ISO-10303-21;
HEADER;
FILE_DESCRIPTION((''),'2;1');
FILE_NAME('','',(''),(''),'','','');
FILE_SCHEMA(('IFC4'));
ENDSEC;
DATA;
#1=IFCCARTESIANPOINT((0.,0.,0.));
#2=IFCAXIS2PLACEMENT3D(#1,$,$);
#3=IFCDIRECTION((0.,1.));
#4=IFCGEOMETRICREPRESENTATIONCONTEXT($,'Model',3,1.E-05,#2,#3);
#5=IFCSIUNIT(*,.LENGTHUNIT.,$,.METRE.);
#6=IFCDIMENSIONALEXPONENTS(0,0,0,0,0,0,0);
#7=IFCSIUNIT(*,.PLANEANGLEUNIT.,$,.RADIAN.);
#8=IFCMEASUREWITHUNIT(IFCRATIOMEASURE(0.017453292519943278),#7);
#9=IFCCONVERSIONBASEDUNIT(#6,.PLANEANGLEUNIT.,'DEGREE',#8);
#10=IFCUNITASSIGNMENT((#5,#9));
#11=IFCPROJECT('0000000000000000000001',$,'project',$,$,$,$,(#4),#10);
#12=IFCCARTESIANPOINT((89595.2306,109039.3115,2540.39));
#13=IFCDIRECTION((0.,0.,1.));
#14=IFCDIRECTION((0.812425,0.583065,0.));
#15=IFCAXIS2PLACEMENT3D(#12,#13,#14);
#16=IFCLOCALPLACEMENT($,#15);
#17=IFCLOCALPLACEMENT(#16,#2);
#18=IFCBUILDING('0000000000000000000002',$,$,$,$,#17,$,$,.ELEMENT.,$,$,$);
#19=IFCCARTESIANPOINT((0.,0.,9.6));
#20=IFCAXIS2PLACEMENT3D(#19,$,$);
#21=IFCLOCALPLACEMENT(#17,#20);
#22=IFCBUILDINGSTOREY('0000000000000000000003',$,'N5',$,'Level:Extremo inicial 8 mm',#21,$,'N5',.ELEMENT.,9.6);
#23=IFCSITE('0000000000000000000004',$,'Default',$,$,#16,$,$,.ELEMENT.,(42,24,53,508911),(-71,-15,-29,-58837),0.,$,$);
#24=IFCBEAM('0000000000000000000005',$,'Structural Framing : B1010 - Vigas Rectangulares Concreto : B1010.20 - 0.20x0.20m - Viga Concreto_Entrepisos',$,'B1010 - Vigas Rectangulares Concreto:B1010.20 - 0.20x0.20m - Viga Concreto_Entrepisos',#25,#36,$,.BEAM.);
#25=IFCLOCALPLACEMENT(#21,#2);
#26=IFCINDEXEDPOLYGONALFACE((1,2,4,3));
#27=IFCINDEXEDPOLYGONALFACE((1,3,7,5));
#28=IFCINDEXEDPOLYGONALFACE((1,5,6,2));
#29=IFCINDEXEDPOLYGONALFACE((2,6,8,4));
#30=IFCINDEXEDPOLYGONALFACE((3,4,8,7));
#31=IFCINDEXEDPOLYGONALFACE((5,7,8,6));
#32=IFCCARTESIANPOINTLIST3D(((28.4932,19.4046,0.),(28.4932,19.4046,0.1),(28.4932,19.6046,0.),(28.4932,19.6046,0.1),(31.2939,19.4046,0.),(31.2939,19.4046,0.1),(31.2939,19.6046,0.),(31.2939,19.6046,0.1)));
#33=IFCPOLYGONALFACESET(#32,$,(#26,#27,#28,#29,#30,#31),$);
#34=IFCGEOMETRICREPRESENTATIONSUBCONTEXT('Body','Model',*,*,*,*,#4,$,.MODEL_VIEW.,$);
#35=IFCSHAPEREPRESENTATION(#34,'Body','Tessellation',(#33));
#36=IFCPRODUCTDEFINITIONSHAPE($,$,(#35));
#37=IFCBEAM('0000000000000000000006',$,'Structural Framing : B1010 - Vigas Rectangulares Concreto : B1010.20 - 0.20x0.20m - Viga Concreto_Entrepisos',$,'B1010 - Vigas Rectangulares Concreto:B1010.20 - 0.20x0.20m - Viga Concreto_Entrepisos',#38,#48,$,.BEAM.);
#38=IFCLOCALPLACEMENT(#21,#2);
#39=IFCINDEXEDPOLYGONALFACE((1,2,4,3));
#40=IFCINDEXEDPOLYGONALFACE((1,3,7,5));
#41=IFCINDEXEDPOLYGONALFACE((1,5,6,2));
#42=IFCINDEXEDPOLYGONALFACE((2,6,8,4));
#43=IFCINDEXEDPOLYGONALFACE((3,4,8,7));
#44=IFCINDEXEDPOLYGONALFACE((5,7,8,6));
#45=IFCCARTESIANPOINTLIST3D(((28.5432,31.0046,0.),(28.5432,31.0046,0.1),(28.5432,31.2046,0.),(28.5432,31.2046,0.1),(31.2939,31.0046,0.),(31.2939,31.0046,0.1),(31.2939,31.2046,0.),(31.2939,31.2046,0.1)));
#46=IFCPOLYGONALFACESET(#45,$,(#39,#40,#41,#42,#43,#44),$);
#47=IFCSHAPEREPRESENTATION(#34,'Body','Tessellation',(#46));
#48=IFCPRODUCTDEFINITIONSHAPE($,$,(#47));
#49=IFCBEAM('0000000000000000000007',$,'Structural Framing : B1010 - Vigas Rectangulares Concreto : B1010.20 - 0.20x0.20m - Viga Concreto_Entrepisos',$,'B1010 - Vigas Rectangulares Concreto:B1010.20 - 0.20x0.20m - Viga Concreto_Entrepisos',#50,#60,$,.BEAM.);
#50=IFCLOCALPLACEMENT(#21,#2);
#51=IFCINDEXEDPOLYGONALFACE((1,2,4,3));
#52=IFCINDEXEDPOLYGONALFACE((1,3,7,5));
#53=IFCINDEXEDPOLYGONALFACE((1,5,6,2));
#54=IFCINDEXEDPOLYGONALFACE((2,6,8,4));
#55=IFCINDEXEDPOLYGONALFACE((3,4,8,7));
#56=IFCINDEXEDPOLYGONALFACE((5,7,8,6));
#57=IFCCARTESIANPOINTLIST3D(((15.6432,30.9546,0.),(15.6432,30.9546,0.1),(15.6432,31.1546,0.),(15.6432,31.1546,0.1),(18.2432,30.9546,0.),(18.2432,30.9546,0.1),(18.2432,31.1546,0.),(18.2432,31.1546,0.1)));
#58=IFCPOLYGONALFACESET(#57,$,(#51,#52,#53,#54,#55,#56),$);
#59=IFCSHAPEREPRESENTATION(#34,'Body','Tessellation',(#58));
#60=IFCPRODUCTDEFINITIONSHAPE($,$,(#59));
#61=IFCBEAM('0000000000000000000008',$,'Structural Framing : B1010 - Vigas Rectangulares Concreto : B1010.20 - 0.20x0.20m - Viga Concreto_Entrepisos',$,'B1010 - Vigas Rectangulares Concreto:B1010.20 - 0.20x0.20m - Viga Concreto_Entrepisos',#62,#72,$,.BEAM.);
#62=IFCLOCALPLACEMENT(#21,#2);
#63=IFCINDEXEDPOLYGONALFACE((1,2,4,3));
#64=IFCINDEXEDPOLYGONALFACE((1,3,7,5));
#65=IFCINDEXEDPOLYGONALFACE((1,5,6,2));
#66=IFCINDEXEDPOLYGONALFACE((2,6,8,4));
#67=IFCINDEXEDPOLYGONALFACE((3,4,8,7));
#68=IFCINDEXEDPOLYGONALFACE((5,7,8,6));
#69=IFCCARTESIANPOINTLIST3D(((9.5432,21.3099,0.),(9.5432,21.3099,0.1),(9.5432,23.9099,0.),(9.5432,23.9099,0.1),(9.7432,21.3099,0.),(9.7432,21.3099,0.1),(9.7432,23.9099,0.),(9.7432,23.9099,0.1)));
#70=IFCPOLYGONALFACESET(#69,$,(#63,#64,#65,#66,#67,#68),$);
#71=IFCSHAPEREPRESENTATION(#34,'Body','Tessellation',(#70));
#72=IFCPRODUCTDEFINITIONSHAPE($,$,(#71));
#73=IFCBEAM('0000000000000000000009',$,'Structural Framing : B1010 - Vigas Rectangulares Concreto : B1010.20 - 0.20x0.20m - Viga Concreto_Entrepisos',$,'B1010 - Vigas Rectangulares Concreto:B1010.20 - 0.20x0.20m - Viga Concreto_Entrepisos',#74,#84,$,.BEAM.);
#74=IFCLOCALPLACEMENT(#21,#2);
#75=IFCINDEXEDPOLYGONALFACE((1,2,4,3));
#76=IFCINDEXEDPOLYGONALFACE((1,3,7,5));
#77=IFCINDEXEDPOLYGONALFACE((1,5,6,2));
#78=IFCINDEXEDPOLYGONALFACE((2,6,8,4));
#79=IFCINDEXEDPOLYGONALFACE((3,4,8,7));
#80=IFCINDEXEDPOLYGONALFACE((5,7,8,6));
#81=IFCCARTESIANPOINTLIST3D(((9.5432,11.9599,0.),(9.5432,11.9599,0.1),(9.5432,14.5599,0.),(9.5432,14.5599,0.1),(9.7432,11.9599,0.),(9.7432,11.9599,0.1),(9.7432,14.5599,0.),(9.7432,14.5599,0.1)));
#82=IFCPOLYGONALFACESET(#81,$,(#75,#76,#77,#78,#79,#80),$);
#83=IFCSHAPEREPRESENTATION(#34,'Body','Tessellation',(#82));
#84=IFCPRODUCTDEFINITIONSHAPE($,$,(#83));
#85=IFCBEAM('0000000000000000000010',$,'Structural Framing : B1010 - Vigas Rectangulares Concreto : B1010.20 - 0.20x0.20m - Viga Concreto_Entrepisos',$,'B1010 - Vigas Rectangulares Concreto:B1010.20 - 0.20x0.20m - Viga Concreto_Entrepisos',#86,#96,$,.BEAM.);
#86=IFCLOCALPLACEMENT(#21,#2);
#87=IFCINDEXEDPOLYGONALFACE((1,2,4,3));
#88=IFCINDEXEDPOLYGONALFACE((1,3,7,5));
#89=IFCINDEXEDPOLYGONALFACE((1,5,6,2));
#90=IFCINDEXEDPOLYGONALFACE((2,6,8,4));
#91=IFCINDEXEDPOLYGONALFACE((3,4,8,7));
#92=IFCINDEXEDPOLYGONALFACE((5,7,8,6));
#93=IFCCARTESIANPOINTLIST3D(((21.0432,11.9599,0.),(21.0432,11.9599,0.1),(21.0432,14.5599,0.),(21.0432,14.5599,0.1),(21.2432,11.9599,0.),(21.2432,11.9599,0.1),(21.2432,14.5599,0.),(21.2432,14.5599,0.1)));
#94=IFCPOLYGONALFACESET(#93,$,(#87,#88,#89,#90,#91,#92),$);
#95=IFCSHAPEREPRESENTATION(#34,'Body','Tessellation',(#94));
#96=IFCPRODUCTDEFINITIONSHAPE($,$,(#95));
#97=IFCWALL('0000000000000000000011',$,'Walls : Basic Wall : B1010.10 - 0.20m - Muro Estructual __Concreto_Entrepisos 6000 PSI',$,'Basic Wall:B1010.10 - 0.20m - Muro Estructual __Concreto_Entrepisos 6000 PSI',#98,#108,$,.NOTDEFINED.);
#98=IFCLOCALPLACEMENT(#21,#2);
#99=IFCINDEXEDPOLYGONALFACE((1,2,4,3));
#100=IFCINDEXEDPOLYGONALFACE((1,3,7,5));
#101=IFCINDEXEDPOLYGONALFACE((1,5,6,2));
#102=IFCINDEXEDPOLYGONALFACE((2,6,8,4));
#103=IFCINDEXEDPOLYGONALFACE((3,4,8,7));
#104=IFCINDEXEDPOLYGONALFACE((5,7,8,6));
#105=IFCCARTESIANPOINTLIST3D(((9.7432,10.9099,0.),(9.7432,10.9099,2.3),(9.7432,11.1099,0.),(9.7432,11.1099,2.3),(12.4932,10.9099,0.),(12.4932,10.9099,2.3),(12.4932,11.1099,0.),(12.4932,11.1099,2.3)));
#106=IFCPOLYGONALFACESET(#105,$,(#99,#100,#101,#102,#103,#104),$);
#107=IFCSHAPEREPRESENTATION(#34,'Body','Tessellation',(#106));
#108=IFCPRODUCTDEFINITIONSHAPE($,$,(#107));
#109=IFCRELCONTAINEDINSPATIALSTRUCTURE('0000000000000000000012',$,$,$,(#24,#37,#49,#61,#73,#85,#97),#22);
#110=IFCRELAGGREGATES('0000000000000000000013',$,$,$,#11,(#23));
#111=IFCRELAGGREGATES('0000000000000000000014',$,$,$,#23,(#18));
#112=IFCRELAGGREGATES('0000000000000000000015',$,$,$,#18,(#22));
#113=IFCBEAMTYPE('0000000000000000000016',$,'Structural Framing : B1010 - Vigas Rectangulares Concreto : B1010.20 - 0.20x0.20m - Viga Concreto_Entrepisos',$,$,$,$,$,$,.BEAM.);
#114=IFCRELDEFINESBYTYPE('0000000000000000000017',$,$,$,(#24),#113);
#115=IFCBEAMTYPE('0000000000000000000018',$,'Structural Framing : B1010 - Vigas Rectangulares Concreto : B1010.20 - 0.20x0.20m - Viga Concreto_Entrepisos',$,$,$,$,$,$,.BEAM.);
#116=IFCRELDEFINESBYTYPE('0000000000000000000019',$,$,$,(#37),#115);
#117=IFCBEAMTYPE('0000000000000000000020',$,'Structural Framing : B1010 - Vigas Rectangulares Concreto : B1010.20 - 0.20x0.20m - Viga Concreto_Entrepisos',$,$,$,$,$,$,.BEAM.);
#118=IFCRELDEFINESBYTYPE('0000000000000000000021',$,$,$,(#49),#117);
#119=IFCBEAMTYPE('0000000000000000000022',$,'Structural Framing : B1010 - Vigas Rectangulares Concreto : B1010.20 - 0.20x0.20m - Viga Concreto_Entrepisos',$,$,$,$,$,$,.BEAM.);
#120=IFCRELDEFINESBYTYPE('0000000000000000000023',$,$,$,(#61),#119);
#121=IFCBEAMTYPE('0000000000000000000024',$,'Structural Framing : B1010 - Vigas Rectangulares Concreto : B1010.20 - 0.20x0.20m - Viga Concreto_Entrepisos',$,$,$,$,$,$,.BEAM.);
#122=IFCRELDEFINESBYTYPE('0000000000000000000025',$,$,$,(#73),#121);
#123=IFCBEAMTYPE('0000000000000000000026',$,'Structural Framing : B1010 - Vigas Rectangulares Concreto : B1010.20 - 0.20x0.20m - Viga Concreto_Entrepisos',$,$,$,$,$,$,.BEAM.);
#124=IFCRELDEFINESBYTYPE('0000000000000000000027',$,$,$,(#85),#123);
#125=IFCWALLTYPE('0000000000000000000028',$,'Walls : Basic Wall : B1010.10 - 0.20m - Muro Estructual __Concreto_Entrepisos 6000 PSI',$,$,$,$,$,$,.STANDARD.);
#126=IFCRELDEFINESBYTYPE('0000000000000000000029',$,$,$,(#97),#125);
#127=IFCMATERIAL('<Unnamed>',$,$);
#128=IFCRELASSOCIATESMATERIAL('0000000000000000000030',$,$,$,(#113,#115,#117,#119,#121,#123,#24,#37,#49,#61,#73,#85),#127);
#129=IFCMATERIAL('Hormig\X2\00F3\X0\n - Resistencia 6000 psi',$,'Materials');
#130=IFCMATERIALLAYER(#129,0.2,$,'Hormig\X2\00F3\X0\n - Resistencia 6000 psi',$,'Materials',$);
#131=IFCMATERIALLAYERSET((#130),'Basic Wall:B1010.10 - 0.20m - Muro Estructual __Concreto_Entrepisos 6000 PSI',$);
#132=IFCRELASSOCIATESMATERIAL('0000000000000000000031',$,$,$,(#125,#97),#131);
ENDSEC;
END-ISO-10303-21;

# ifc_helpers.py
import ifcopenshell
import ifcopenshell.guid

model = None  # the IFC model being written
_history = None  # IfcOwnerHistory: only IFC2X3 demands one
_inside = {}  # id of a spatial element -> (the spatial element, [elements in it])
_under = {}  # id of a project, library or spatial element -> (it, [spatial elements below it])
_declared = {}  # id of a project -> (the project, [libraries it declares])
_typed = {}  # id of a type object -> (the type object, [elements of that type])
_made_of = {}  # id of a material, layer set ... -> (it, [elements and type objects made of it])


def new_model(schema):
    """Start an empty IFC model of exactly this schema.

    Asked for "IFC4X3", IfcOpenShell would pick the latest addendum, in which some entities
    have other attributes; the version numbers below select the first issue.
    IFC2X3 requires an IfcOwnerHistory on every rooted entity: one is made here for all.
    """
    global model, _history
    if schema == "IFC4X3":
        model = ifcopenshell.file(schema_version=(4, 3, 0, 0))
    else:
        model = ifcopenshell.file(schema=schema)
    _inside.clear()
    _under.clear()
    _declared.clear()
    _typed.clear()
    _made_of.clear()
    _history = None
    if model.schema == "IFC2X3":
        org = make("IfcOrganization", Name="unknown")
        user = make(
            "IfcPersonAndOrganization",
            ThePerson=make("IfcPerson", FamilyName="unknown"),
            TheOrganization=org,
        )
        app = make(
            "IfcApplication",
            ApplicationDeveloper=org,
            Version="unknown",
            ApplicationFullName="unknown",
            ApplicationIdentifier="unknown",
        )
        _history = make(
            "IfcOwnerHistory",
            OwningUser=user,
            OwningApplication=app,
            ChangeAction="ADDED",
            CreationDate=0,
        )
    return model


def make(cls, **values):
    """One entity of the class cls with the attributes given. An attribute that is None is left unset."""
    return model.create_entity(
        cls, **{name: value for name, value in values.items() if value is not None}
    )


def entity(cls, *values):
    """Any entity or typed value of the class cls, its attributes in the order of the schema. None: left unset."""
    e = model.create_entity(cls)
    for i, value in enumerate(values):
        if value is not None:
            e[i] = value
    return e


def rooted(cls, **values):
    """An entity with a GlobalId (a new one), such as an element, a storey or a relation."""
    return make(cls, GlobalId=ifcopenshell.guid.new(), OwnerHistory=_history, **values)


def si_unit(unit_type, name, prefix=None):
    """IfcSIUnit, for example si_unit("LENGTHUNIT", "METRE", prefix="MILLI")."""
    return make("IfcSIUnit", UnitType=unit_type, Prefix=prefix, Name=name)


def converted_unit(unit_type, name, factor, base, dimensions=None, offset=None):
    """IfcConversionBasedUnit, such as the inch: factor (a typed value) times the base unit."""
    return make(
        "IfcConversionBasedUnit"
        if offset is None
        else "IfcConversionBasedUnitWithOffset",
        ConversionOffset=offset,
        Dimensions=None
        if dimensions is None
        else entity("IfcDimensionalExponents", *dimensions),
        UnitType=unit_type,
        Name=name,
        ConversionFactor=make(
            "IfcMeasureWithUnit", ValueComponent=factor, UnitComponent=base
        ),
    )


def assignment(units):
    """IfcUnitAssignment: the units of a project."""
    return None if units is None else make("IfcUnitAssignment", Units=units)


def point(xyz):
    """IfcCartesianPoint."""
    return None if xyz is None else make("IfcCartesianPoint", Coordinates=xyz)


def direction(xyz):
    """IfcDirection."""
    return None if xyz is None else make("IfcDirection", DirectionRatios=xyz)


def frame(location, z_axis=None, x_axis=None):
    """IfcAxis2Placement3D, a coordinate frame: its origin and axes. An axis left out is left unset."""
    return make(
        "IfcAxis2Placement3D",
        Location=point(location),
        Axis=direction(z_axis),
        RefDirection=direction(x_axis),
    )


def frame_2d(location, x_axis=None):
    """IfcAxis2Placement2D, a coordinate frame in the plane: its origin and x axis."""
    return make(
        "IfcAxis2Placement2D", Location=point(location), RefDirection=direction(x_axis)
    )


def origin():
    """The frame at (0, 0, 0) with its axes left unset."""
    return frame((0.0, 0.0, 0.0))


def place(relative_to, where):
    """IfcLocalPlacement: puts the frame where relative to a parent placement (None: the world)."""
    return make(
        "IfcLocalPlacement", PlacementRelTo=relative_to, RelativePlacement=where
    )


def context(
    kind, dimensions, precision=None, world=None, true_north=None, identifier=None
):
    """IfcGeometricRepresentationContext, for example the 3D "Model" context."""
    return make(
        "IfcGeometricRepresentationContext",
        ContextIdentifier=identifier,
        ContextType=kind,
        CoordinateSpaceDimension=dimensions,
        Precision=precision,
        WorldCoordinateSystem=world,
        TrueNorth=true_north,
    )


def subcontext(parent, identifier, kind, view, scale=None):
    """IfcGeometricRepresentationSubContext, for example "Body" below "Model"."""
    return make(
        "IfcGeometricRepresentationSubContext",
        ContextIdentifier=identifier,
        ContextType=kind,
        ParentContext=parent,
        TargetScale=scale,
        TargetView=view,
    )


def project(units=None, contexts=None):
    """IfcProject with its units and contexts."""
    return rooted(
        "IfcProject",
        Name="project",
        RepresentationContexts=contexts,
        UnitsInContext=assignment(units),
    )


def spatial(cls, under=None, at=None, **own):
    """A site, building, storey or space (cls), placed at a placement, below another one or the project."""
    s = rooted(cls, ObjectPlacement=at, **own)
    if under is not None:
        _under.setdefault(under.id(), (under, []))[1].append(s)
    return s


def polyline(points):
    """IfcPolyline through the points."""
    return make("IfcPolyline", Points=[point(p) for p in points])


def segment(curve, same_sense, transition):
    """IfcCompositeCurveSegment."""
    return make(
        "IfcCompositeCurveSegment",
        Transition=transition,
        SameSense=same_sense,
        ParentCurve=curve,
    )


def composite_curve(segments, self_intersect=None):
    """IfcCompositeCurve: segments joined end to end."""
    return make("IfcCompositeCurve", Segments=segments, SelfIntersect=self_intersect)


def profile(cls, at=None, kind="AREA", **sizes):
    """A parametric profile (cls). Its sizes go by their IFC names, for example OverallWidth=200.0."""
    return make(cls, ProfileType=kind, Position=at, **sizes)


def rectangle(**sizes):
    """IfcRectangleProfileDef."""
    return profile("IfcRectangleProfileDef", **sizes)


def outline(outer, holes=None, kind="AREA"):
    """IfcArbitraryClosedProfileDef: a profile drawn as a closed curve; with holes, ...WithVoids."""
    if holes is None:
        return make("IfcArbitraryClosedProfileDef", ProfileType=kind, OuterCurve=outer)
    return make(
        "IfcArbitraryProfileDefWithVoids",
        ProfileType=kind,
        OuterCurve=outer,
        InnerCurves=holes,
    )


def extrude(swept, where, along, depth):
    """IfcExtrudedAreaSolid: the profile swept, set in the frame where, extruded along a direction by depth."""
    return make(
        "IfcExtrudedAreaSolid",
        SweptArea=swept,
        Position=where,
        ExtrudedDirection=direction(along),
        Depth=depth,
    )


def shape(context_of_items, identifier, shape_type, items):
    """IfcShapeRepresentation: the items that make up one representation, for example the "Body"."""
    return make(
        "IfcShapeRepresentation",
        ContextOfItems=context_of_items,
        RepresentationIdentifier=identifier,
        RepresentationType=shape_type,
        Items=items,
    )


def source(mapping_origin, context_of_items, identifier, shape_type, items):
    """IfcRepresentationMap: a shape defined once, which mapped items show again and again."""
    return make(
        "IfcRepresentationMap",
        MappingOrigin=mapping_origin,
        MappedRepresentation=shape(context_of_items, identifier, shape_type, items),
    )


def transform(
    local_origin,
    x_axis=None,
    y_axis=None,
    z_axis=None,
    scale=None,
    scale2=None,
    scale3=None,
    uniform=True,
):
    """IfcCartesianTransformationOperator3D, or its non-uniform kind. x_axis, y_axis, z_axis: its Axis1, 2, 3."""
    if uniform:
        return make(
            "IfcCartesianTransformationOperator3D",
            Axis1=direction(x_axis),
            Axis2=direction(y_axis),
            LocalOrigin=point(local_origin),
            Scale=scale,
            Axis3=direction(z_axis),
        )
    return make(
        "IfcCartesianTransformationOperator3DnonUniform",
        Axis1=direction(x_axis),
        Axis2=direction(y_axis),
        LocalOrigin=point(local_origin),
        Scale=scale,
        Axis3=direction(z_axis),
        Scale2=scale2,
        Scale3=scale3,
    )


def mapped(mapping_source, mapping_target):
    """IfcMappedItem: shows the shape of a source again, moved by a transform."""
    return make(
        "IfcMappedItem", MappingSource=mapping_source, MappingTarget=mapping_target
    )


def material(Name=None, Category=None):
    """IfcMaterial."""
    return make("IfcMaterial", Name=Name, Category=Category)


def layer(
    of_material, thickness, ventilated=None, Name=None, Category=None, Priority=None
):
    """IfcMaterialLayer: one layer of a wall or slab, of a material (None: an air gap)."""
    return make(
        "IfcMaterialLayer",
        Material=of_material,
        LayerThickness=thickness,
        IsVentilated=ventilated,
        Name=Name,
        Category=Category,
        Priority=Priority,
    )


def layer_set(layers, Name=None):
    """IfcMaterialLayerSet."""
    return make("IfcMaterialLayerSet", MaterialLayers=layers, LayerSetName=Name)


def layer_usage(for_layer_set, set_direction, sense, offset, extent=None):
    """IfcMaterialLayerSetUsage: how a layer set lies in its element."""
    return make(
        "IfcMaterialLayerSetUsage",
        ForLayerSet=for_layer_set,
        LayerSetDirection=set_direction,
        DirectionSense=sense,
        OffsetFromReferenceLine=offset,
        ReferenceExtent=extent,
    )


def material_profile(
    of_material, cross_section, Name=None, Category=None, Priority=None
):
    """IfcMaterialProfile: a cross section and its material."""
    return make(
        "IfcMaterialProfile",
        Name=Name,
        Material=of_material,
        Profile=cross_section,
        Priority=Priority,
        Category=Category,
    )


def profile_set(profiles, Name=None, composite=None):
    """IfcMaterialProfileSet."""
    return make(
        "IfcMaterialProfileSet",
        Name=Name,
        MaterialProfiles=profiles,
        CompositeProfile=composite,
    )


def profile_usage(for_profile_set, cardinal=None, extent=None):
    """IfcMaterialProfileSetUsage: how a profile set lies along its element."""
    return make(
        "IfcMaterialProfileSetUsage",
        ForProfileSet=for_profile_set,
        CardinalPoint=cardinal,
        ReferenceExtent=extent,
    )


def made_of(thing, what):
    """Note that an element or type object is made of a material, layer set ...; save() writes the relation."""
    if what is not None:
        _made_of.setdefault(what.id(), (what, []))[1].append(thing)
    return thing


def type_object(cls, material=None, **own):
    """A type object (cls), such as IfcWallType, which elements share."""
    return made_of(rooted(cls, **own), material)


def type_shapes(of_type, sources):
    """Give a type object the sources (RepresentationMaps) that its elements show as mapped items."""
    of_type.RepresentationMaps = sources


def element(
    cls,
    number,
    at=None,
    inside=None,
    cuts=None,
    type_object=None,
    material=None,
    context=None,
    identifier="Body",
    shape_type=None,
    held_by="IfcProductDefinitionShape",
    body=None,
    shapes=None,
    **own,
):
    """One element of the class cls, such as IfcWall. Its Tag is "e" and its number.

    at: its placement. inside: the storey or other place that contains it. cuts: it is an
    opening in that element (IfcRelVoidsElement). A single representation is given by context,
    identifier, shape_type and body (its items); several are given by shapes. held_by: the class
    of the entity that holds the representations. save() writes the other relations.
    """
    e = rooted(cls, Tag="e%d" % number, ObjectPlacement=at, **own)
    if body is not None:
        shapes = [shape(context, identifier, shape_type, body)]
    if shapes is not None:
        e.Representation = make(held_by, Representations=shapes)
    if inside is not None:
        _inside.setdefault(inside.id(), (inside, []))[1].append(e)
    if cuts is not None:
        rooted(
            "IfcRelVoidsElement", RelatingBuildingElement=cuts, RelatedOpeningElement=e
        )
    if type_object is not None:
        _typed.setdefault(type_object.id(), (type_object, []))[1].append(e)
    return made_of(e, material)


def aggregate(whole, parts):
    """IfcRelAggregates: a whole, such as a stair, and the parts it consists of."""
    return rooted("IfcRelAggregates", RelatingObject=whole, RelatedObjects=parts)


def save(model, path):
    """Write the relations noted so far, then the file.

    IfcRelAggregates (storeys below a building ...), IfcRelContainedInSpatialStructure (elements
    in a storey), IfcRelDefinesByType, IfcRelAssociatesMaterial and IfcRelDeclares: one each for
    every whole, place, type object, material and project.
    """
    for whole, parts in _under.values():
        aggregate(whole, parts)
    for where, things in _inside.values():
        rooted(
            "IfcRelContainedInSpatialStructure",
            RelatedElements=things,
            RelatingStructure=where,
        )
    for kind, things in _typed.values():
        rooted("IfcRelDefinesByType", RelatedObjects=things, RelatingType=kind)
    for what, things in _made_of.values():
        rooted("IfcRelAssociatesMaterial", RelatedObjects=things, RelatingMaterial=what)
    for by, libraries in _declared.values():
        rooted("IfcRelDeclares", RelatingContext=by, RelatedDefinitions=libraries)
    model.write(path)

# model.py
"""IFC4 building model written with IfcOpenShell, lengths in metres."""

from ifc_helpers import new_model, entity, si_unit, converted_unit, direction, frame, frame_2d, origin, place, context, subcontext, project, spatial, polyline, segment, composite_curve, rectangle, outline, extrude, source, transform, mapped, material, layer, layer_set, layer_usage, material_profile, profile_set, profile_usage, type_object, type_shapes, element, save


model = new_model("IFC4")

# Units and contexts
model_context = context("Model", 3, precision=1e-05, world=origin(), true_north=direction((0.0, 1.0)))
body_context = subcontext(model_context, "Body", "Model", "MODEL_VIEW")
ifc_project = project(units=[si_unit("LENGTHUNIT", "METRE"), converted_unit("PLANEANGLEUNIT", "DEGREE", entity("IfcRatioMeasure", 0.017453292519943278), si_unit("PLANEANGLEUNIT", "RADIAN"), dimensions=[0, 0, 0, 0, 0, 0, 0])], contexts=[model_context])

# Site, building, storey
site_placement = place(None, frame((89595.2306, 109039.3115, 2540.39), z_axis=(0.0, 0.0, 1.0), x_axis=(0.812425, 0.583065, 0.0)))
site = spatial("IfcSite", under=ifc_project, at=site_placement, Name="Default", CompositionType="ELEMENT", RefLatitude=(42, 24, 53, 508911), RefLongitude=(-71, -15, -29, -58837), RefElevation=0.0)
building_placement = place(site_placement, origin())
building = spatial("IfcBuilding", under=site, at=building_placement, CompositionType="ELEMENT")
storey_placement = place(building_placement, frame((0.0, 0.0, 9.6)))
storey = spatial("IfcBuildingStorey", under=building, at=storey_placement, Name="N5", ObjectType="Level:Extremo inicial 8 mm", LongName="N5", CompositionType="ELEMENT", Elevation=9.6)

# Beams
ifc_material_1 = material(Name="<Unnamed>")
ifc_material_profile_1 = material_profile(ifc_material_1, outline(composite_curve([segment(polyline([(-0.1, 0.0, 0.0), (-0.1, 0.1, 0.0)]), True, "CONTINUOUS"), segment(polyline([(-0.1, 0.1, 0.0), (0.1, 0.1, 0.0)]), True, "CONTINUOUS"), segment(polyline([(0.1, 0.1, 0.0), (0.1, 0.0, 0.0)]), True, "CONTINUOUS"), segment(polyline([(0.1, 0.0, 0.0), (-0.1, 0.0, 0.0)]), True, "CONTINUOUS")], self_intersect=False), kind="CURVE"), Name="B1010.20 - 0.20x0.20m - Viga Concreto_Entrepisos")
ifc_material_profile_2 = material_profile(ifc_material_1, outline(composite_curve([segment(polyline([(-1.4004, -0.1, 0.1), (-1.4004, 0.1, 0.1)]), True, "CONTINUOUS"), segment(polyline([(-1.4004, 0.1, 0.1), (-1.4004, 0.1, -0.1)]), True, "CONTINUOUS"), segment(polyline([(-1.4004, 0.1, -0.1), (-1.4004, -0.1, -0.1)]), True, "CONTINUOUS"), segment(polyline([(-1.4004, -0.1, -0.1), (-1.4004, -0.1, 0.1)]), True, "CONTINUOUS")], self_intersect=False), kind="CURVE"), Name="B1010.20 - 0.20x0.20m - Viga Concreto_Entrepisos")
ifc_profile_set_1 = profile_set([ifc_material_profile_1, ifc_material_profile_2], Name="B1010.20 - 0.20x0.20m - Viga Concreto_Entrepisos")
ifc_profile_usage_1 = profile_usage(ifc_profile_set_1, cardinal=8)
beam_type_1 = type_object("IfcBeamType", Name="Structural Framing : B1010 - Vigas Rectangulares Concreto : B1010.20 - 0.20x0.20m - Viga Concreto_Entrepisos", PredefinedType="BEAM", material=ifc_profile_set_1)
shared_shape_1 = source(origin(), body_context, "Body", "SweptSolid", [
    extrude(rectangle(XDim=0.1, YDim=0.2, at=frame_2d((0.0, 0.0), x_axis=(1.0, 0.0))), frame((31.2939, 19.5046, 9.65), z_axis=(-1.0, 0.0, 0.0), x_axis=(0.0, 0.0, -1.0)), (0.0, 0.0, 1.0), 2.8007),
])
type_shapes(beam_type_1, [shared_shape_1])
beam_1_placement = place(storey_placement, frame((0.0, 0.0, -9.6)))
element("IfcBeam", 1, at=beam_1_placement, inside=storey, type_object=beam_type_1, material=ifc_profile_usage_1, Name="Structural Framing : B1010 - Vigas Rectangulares Concreto : B1010.20 - 0.20x0.20m - Viga Concreto_Entrepisos", ObjectType="B1010 - Vigas Rectangulares Concreto:B1010.20 - 0.20x0.20m - Viga Concreto_Entrepisos", PredefinedType="BEAM", context=body_context, shape_type="MappedRepresentation", body=[
    mapped(shared_shape_1, transform((0.0, 0.0, 0.0), scale=1.0)),
])
ifc_profile_usage_2 = profile_usage(ifc_profile_set_1, cardinal=8)
beam_type_2 = type_object("IfcBeamType", Name="Structural Framing : B1010 - Vigas Rectangulares Concreto : B1010.20 - 0.20x0.20m - Viga Concreto_Entrepisos", PredefinedType="BEAM", material=ifc_profile_set_1)
shared_shape_2 = source(origin(), body_context, "Body", "SweptSolid", [
    extrude(rectangle(XDim=0.1, YDim=0.2, at=frame_2d((0.0, 0.0), x_axis=(1.0, 0.0))), frame((31.2939, 31.1046, 9.65), z_axis=(-1.0, 0.0, 0.0), x_axis=(0.0, 0.0, -1.0)), (0.0, 0.0, 1.0), 2.7507),
])
type_shapes(beam_type_2, [shared_shape_2])
beam_2_placement = place(storey_placement, frame((0.0, 0.0, -9.6)))
element("IfcBeam", 2, at=beam_2_placement, inside=storey, type_object=beam_type_2, material=ifc_profile_usage_2, Name="Structural Framing : B1010 - Vigas Rectangulares Concreto : B1010.20 - 0.20x0.20m - Viga Concreto_Entrepisos", ObjectType="B1010 - Vigas Rectangulares Concreto:B1010.20 - 0.20x0.20m - Viga Concreto_Entrepisos", PredefinedType="BEAM", context=body_context, shape_type="MappedRepresentation", body=[
    mapped(shared_shape_2, transform((0.0, 0.0, 0.0), scale=1.0)),
])
ifc_profile_usage_3 = profile_usage(ifc_profile_set_1, cardinal=8)
beam_type_3 = type_object("IfcBeamType", Name="Structural Framing : B1010 - Vigas Rectangulares Concreto : B1010.20 - 0.20x0.20m - Viga Concreto_Entrepisos", PredefinedType="BEAM", material=ifc_profile_set_1)
shared_shape_3 = source(origin(), body_context, "Body", "SweptSolid", [
    extrude(rectangle(XDim=0.1, YDim=0.2, at=frame_2d((0.0, 0.0), x_axis=(1.0, 0.0))), frame((18.2432, 31.0546, 9.65), z_axis=(-1.0, 0.0, 0.0), x_axis=(0.0, 0.0, -1.0)), (0.0, 0.0, 1.0), 2.6),
])
type_shapes(beam_type_3, [shared_shape_3])
beam_3_placement = place(storey_placement, frame((0.0, 0.0, -9.6)))
element("IfcBeam", 3, at=beam_3_placement, inside=storey, type_object=beam_type_3, material=ifc_profile_usage_3, Name="Structural Framing : B1010 - Vigas Rectangulares Concreto : B1010.20 - 0.20x0.20m - Viga Concreto_Entrepisos", ObjectType="B1010 - Vigas Rectangulares Concreto:B1010.20 - 0.20x0.20m - Viga Concreto_Entrepisos", PredefinedType="BEAM", context=body_context, shape_type="MappedRepresentation", body=[
    mapped(shared_shape_3, transform((0.0, 0.0, 0.0), scale=1.0)),
])
ifc_profile_usage_4 = profile_usage(ifc_profile_set_1, cardinal=8)
beam_type_4 = type_object("IfcBeamType", Name="Structural Framing : B1010 - Vigas Rectangulares Concreto : B1010.20 - 0.20x0.20m - Viga Concreto_Entrepisos", PredefinedType="BEAM", material=ifc_profile_set_1)
shared_shape_4 = source(origin(), body_context, "Body", "SweptSolid", [
    extrude(rectangle(XDim=0.1, YDim=0.2, at=frame_2d((0.0, 0.0), x_axis=(0.0, 1.0))), frame((9.6432, 21.3099, 9.65), z_axis=(0.0, 1.0, 0.0), x_axis=(-1.0, 0.0, 0.0)), (0.0, 0.0, 1.0), 2.6),
])
type_shapes(beam_type_4, [shared_shape_4])
beam_4_placement = place(storey_placement, frame((0.0, 0.0, -9.6)))
element("IfcBeam", 4, at=beam_4_placement, inside=storey, type_object=beam_type_4, material=ifc_profile_usage_4, Name="Structural Framing : B1010 - Vigas Rectangulares Concreto : B1010.20 - 0.20x0.20m - Viga Concreto_Entrepisos", ObjectType="B1010 - Vigas Rectangulares Concreto:B1010.20 - 0.20x0.20m - Viga Concreto_Entrepisos", PredefinedType="BEAM", context=body_context, shape_type="MappedRepresentation", body=[
    mapped(shared_shape_4, transform((0.0, 0.0, 0.0), scale=1.0)),
])
ifc_profile_usage_5 = profile_usage(ifc_profile_set_1, cardinal=8)
beam_type_5 = type_object("IfcBeamType", Name="Structural Framing : B1010 - Vigas Rectangulares Concreto : B1010.20 - 0.20x0.20m - Viga Concreto_Entrepisos", PredefinedType="BEAM", material=ifc_profile_set_1)
shared_shape_5 = source(origin(), body_context, "Body", "SweptSolid", [
    extrude(rectangle(XDim=0.1, YDim=0.2, at=frame_2d((0.0, 0.0), x_axis=(0.0, 1.0))), frame((9.6432, 11.9599, 9.65), z_axis=(0.0, 1.0, 0.0), x_axis=(-1.0, 0.0, 0.0)), (0.0, 0.0, 1.0), 2.6),
])
type_shapes(beam_type_5, [shared_shape_5])
beam_5_placement = place(storey_placement, frame((0.0, 0.0, -9.6)))
element("IfcBeam", 5, at=beam_5_placement, inside=storey, type_object=beam_type_5, material=ifc_profile_usage_5, Name="Structural Framing : B1010 - Vigas Rectangulares Concreto : B1010.20 - 0.20x0.20m - Viga Concreto_Entrepisos", ObjectType="B1010 - Vigas Rectangulares Concreto:B1010.20 - 0.20x0.20m - Viga Concreto_Entrepisos", PredefinedType="BEAM", context=body_context, shape_type="MappedRepresentation", body=[
    mapped(shared_shape_5, transform((0.0, 0.0, 0.0), scale=1.0)),
])
ifc_profile_usage_6 = profile_usage(ifc_profile_set_1, cardinal=8)
beam_type_6 = type_object("IfcBeamType", Name="Structural Framing : B1010 - Vigas Rectangulares Concreto : B1010.20 - 0.20x0.20m - Viga Concreto_Entrepisos", PredefinedType="BEAM", material=ifc_profile_set_1)
shared_shape_6 = source(origin(), body_context, "Body", "SweptSolid", [
    extrude(rectangle(XDim=0.1, YDim=0.2, at=frame_2d((0.0, 0.0), x_axis=(0.0, 1.0))), frame((21.1432, 11.9599, 9.65), z_axis=(0.0, 1.0, 0.0), x_axis=(-1.0, 0.0, 0.0)), (0.0, 0.0, 1.0), 2.6),
])
type_shapes(beam_type_6, [shared_shape_6])
beam_6_placement = place(storey_placement, frame((0.0, 0.0, -9.6)))
element("IfcBeam", 6, at=beam_6_placement, inside=storey, type_object=beam_type_6, material=ifc_profile_usage_6, Name="Structural Framing : B1010 - Vigas Rectangulares Concreto : B1010.20 - 0.20x0.20m - Viga Concreto_Entrepisos", ObjectType="B1010 - Vigas Rectangulares Concreto:B1010.20 - 0.20x0.20m - Viga Concreto_Entrepisos", PredefinedType="BEAM", context=body_context, shape_type="MappedRepresentation", body=[
    mapped(shared_shape_6, transform((0.0, 0.0, 0.0), scale=1.0)),
])

# Wall
ifc_material_2 = material(Name="Hormigón - Resistencia 6000 psi", Category="Materials")
ifc_layer_1 = layer(ifc_material_2, 0.2, Name="Hormigón - Resistencia 6000 psi", Category="Materials")
ifc_layer_set_1 = layer_set([ifc_layer_1], Name="Basic Wall:B1010.10 - 0.20m - Muro Estructual __Concreto_Entrepisos 6000 PSI")
ifc_layer_usage_1 = layer_usage(ifc_layer_set_1, "AXIS2", "POSITIVE", -0.1)
wall_type = type_object("IfcWallType", Name="Walls : Basic Wall : B1010.10 - 0.20m - Muro Estructual __Concreto_Entrepisos 6000 PSI", PredefinedType="STANDARD", material=ifc_layer_set_1)
wall_placement = place(storey_placement, frame((9.7432, 11.0099, 0.0)))
element("IfcWall", 7, at=wall_placement, inside=storey, type_object=wall_type, material=ifc_layer_usage_1, Name="Walls : Basic Wall : B1010.10 - 0.20m - Muro Estructual __Concreto_Entrepisos 6000 PSI", ObjectType="Basic Wall:B1010.10 - 0.20m - Muro Estructual __Concreto_Entrepisos 6000 PSI", PredefinedType="NOTDEFINED", context=body_context, shape_type="SweptSolid", body=[
    extrude(rectangle(XDim=2.75, YDim=0.2, at=frame_2d((1.375, 0.0), x_axis=(-1.0, 0.0))), origin(), (0.0, 0.0, 1.0), 2.3),
])

save(model, "model.ifc")
